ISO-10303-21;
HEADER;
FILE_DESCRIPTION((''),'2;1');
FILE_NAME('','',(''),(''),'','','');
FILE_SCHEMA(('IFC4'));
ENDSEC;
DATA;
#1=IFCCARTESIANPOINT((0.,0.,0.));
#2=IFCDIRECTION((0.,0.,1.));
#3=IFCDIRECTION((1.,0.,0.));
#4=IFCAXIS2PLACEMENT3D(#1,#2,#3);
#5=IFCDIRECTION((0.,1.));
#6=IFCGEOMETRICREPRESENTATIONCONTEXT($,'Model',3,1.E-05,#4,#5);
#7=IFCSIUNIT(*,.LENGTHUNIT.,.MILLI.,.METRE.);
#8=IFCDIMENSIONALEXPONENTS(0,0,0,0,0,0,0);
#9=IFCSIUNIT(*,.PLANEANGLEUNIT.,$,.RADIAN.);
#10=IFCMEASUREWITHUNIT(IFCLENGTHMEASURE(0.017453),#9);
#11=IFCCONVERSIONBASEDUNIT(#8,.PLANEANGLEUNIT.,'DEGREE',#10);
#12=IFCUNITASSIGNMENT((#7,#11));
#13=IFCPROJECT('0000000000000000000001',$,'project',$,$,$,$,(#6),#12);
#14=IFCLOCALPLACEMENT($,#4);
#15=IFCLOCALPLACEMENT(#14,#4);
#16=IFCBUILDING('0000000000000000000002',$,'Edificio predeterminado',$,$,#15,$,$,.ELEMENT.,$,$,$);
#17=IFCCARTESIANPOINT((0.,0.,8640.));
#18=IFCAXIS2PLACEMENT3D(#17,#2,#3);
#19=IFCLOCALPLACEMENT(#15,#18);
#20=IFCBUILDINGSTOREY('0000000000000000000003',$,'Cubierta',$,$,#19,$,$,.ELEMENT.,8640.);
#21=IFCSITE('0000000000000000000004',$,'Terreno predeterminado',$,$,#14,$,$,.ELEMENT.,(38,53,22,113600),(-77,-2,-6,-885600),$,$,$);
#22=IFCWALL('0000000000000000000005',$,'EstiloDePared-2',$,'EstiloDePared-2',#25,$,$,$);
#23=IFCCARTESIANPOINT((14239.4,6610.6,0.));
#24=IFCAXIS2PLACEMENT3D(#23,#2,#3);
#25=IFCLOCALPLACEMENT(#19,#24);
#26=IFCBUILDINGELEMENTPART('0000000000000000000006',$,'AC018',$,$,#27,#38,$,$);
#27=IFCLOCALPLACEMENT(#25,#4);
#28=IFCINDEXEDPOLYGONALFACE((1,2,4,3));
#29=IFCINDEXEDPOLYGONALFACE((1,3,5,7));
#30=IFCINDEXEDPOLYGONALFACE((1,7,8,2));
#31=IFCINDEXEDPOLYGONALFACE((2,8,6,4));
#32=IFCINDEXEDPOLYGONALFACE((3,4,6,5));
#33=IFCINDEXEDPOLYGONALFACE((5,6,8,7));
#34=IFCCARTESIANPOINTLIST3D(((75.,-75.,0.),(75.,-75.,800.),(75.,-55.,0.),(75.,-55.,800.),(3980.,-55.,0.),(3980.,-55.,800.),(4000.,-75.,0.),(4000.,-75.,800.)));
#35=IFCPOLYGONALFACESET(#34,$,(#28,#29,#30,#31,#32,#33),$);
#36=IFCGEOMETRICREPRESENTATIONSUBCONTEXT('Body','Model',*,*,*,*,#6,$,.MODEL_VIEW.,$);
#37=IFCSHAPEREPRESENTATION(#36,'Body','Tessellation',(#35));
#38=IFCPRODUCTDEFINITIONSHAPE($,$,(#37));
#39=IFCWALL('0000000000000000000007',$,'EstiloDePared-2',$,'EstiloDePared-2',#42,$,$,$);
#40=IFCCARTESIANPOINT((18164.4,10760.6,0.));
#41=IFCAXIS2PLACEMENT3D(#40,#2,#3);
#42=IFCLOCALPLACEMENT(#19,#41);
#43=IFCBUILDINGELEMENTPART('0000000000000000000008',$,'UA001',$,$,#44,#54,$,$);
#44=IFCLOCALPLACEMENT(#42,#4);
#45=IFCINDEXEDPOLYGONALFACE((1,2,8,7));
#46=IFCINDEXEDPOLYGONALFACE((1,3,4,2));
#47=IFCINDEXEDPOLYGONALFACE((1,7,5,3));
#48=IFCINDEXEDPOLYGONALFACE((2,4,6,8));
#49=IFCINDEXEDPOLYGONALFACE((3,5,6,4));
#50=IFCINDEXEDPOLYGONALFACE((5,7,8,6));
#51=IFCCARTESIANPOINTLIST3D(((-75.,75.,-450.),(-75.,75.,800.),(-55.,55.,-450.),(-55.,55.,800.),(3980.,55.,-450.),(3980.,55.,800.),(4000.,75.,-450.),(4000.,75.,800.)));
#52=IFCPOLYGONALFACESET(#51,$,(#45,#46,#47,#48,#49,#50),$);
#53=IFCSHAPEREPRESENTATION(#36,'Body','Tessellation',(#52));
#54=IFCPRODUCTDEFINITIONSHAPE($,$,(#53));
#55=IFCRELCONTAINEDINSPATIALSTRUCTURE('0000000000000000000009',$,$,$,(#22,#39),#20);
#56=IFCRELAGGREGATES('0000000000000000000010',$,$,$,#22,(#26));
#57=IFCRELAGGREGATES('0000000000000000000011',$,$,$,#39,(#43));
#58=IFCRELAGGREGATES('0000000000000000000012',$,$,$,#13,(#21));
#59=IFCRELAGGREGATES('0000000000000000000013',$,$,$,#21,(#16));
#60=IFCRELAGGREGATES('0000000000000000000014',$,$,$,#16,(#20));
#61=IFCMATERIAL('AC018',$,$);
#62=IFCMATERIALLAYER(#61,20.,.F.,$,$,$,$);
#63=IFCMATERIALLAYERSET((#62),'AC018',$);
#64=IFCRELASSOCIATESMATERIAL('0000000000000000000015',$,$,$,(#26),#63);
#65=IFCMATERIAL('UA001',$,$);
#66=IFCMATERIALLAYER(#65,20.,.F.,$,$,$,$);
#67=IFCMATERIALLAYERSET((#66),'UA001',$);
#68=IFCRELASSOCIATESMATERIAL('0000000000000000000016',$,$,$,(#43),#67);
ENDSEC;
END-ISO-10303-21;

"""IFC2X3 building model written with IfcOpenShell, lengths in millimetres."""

from ifc_helpers import new_model, entity, si_unit, converted_unit, direction, frame, origin_with_axes, place, context, subcontext, project, spatial, polyline, outline, extrude, material, layer, layer_set, layer_usage, element, aggregate, save


model = new_model("IFC2X3")

# Units and contexts
model_context = context("Model", 3, precision=1e-05, world=origin_with_axes(), true_north=direction((0.0, 1.0)))
body_context = subcontext(model_context, "Body", "Model", "MODEL_VIEW")
ifc_project = project(units=[si_unit("LENGTHUNIT", "METRE", prefix="MILLI"), converted_unit("PLANEANGLEUNIT", "DEGREE", entity("IfcLengthMeasure", 0.017453), si_unit("PLANEANGLEUNIT", "RADIAN"), dimensions=[0, 0, 0, 0, 0, 0, 0])], contexts=[model_context])

# Site, building, storey
site_placement = place(None, origin_with_axes())
site = spatial("IfcSite", under=ifc_project, at=site_placement, Name="Terreno predeterminado", CompositionType="ELEMENT", RefLatitude=(38, 53, 22, 113600), RefLongitude=(-77, -2, -6, -885600))
building_placement = place(site_placement, origin_with_axes())
building = spatial("IfcBuilding", under=site, at=building_placement, Name="Edificio predeterminado", CompositionType="ELEMENT")
storey_placement = place(building_placement, frame((0.0, 0.0, 8640.0), z_axis=(0.0, 0.0, 1.0), x_axis=(1.0, 0.0, 0.0)))
storey = spatial("IfcBuildingStorey", under=building, at=storey_placement, Name="Cubierta", CompositionType="ELEMENT", Elevation=8640.0)

# Walls, building element parts
wall_1_placement = place(storey_placement, frame((14239.4, 6610.6, 0.0), z_axis=(0.0, 0.0, 1.0), x_axis=(1.0, 0.0, 0.0)))
wall_1 = element("IfcWall", 1, at=wall_1_placement, inside=storey, Name="EstiloDePared-2", ObjectType="EstiloDePared-2")
ifc_material_1 = material(Name="AC018")
ifc_layer_1 = layer(ifc_material_1, 20.0, ventilated=False)
ifc_layer_set_1 = layer_set([ifc_layer_1], Name="AC018")
ifc_layer_usage_1 = layer_usage(ifc_layer_set_1, "AXIS2", "NEGATIVE", 55.0)
building_element_part_1_placement = place(wall_1_placement, origin_with_axes())
building_element_part_1 = element("IfcBuildingElementPart", 2, at=building_element_part_1_placement, material=ifc_layer_usage_1, Name="AC018", context=body_context, shape_type="SweptSolid", body=[
    extrude(outline(polyline([(3980.0, -55.0), (4000.0, -75.0), (75.0, -75.0), (75.0, -55.0), (3980.0, -55.0)])), origin_with_axes(), (0.0, 0.0, 1.0), 800.0),
])
aggregate(wall_1, [building_element_part_1])
wall_2_placement = place(storey_placement, frame((18164.4, 10760.6, 0.0), z_axis=(0.0, 0.0, 1.0), x_axis=(1.0, 0.0, 0.0)))
wall_2 = element("IfcWall", 3, at=wall_2_placement, inside=storey, Name="EstiloDePared-2", ObjectType="EstiloDePared-2")
ifc_material_2 = material(Name="UA001")
ifc_layer_2 = layer(ifc_material_2, 20.0, ventilated=False)
ifc_layer_set_2 = layer_set([ifc_layer_2], Name="UA001")
ifc_layer_usage_2 = layer_usage(ifc_layer_set_2, "AXIS2", "NEGATIVE", -75.0)
building_element_part_2_placement = place(wall_2_placement, origin_with_axes())
building_element_part_2 = element("IfcBuildingElementPart", 4, at=building_element_part_2_placement, material=ifc_layer_usage_2, Name="UA001", context=body_context, shape_type="SweptSolid", body=[
    extrude(outline(polyline([(4000.0, 75.0), (3980.0, 55.0), (-55.0, 55.0), (-75.0, 75.0), (4000.0, 75.0)])), frame((0.0, 0.0, -450.0), z_axis=(0.0, 0.0, 1.0), x_axis=(1.0, 0.0, 0.0)), (0.0, 0.0, 1.0), 1250.0),
])
aggregate(wall_2, [building_element_part_2])

save(model, "model.ifc")
